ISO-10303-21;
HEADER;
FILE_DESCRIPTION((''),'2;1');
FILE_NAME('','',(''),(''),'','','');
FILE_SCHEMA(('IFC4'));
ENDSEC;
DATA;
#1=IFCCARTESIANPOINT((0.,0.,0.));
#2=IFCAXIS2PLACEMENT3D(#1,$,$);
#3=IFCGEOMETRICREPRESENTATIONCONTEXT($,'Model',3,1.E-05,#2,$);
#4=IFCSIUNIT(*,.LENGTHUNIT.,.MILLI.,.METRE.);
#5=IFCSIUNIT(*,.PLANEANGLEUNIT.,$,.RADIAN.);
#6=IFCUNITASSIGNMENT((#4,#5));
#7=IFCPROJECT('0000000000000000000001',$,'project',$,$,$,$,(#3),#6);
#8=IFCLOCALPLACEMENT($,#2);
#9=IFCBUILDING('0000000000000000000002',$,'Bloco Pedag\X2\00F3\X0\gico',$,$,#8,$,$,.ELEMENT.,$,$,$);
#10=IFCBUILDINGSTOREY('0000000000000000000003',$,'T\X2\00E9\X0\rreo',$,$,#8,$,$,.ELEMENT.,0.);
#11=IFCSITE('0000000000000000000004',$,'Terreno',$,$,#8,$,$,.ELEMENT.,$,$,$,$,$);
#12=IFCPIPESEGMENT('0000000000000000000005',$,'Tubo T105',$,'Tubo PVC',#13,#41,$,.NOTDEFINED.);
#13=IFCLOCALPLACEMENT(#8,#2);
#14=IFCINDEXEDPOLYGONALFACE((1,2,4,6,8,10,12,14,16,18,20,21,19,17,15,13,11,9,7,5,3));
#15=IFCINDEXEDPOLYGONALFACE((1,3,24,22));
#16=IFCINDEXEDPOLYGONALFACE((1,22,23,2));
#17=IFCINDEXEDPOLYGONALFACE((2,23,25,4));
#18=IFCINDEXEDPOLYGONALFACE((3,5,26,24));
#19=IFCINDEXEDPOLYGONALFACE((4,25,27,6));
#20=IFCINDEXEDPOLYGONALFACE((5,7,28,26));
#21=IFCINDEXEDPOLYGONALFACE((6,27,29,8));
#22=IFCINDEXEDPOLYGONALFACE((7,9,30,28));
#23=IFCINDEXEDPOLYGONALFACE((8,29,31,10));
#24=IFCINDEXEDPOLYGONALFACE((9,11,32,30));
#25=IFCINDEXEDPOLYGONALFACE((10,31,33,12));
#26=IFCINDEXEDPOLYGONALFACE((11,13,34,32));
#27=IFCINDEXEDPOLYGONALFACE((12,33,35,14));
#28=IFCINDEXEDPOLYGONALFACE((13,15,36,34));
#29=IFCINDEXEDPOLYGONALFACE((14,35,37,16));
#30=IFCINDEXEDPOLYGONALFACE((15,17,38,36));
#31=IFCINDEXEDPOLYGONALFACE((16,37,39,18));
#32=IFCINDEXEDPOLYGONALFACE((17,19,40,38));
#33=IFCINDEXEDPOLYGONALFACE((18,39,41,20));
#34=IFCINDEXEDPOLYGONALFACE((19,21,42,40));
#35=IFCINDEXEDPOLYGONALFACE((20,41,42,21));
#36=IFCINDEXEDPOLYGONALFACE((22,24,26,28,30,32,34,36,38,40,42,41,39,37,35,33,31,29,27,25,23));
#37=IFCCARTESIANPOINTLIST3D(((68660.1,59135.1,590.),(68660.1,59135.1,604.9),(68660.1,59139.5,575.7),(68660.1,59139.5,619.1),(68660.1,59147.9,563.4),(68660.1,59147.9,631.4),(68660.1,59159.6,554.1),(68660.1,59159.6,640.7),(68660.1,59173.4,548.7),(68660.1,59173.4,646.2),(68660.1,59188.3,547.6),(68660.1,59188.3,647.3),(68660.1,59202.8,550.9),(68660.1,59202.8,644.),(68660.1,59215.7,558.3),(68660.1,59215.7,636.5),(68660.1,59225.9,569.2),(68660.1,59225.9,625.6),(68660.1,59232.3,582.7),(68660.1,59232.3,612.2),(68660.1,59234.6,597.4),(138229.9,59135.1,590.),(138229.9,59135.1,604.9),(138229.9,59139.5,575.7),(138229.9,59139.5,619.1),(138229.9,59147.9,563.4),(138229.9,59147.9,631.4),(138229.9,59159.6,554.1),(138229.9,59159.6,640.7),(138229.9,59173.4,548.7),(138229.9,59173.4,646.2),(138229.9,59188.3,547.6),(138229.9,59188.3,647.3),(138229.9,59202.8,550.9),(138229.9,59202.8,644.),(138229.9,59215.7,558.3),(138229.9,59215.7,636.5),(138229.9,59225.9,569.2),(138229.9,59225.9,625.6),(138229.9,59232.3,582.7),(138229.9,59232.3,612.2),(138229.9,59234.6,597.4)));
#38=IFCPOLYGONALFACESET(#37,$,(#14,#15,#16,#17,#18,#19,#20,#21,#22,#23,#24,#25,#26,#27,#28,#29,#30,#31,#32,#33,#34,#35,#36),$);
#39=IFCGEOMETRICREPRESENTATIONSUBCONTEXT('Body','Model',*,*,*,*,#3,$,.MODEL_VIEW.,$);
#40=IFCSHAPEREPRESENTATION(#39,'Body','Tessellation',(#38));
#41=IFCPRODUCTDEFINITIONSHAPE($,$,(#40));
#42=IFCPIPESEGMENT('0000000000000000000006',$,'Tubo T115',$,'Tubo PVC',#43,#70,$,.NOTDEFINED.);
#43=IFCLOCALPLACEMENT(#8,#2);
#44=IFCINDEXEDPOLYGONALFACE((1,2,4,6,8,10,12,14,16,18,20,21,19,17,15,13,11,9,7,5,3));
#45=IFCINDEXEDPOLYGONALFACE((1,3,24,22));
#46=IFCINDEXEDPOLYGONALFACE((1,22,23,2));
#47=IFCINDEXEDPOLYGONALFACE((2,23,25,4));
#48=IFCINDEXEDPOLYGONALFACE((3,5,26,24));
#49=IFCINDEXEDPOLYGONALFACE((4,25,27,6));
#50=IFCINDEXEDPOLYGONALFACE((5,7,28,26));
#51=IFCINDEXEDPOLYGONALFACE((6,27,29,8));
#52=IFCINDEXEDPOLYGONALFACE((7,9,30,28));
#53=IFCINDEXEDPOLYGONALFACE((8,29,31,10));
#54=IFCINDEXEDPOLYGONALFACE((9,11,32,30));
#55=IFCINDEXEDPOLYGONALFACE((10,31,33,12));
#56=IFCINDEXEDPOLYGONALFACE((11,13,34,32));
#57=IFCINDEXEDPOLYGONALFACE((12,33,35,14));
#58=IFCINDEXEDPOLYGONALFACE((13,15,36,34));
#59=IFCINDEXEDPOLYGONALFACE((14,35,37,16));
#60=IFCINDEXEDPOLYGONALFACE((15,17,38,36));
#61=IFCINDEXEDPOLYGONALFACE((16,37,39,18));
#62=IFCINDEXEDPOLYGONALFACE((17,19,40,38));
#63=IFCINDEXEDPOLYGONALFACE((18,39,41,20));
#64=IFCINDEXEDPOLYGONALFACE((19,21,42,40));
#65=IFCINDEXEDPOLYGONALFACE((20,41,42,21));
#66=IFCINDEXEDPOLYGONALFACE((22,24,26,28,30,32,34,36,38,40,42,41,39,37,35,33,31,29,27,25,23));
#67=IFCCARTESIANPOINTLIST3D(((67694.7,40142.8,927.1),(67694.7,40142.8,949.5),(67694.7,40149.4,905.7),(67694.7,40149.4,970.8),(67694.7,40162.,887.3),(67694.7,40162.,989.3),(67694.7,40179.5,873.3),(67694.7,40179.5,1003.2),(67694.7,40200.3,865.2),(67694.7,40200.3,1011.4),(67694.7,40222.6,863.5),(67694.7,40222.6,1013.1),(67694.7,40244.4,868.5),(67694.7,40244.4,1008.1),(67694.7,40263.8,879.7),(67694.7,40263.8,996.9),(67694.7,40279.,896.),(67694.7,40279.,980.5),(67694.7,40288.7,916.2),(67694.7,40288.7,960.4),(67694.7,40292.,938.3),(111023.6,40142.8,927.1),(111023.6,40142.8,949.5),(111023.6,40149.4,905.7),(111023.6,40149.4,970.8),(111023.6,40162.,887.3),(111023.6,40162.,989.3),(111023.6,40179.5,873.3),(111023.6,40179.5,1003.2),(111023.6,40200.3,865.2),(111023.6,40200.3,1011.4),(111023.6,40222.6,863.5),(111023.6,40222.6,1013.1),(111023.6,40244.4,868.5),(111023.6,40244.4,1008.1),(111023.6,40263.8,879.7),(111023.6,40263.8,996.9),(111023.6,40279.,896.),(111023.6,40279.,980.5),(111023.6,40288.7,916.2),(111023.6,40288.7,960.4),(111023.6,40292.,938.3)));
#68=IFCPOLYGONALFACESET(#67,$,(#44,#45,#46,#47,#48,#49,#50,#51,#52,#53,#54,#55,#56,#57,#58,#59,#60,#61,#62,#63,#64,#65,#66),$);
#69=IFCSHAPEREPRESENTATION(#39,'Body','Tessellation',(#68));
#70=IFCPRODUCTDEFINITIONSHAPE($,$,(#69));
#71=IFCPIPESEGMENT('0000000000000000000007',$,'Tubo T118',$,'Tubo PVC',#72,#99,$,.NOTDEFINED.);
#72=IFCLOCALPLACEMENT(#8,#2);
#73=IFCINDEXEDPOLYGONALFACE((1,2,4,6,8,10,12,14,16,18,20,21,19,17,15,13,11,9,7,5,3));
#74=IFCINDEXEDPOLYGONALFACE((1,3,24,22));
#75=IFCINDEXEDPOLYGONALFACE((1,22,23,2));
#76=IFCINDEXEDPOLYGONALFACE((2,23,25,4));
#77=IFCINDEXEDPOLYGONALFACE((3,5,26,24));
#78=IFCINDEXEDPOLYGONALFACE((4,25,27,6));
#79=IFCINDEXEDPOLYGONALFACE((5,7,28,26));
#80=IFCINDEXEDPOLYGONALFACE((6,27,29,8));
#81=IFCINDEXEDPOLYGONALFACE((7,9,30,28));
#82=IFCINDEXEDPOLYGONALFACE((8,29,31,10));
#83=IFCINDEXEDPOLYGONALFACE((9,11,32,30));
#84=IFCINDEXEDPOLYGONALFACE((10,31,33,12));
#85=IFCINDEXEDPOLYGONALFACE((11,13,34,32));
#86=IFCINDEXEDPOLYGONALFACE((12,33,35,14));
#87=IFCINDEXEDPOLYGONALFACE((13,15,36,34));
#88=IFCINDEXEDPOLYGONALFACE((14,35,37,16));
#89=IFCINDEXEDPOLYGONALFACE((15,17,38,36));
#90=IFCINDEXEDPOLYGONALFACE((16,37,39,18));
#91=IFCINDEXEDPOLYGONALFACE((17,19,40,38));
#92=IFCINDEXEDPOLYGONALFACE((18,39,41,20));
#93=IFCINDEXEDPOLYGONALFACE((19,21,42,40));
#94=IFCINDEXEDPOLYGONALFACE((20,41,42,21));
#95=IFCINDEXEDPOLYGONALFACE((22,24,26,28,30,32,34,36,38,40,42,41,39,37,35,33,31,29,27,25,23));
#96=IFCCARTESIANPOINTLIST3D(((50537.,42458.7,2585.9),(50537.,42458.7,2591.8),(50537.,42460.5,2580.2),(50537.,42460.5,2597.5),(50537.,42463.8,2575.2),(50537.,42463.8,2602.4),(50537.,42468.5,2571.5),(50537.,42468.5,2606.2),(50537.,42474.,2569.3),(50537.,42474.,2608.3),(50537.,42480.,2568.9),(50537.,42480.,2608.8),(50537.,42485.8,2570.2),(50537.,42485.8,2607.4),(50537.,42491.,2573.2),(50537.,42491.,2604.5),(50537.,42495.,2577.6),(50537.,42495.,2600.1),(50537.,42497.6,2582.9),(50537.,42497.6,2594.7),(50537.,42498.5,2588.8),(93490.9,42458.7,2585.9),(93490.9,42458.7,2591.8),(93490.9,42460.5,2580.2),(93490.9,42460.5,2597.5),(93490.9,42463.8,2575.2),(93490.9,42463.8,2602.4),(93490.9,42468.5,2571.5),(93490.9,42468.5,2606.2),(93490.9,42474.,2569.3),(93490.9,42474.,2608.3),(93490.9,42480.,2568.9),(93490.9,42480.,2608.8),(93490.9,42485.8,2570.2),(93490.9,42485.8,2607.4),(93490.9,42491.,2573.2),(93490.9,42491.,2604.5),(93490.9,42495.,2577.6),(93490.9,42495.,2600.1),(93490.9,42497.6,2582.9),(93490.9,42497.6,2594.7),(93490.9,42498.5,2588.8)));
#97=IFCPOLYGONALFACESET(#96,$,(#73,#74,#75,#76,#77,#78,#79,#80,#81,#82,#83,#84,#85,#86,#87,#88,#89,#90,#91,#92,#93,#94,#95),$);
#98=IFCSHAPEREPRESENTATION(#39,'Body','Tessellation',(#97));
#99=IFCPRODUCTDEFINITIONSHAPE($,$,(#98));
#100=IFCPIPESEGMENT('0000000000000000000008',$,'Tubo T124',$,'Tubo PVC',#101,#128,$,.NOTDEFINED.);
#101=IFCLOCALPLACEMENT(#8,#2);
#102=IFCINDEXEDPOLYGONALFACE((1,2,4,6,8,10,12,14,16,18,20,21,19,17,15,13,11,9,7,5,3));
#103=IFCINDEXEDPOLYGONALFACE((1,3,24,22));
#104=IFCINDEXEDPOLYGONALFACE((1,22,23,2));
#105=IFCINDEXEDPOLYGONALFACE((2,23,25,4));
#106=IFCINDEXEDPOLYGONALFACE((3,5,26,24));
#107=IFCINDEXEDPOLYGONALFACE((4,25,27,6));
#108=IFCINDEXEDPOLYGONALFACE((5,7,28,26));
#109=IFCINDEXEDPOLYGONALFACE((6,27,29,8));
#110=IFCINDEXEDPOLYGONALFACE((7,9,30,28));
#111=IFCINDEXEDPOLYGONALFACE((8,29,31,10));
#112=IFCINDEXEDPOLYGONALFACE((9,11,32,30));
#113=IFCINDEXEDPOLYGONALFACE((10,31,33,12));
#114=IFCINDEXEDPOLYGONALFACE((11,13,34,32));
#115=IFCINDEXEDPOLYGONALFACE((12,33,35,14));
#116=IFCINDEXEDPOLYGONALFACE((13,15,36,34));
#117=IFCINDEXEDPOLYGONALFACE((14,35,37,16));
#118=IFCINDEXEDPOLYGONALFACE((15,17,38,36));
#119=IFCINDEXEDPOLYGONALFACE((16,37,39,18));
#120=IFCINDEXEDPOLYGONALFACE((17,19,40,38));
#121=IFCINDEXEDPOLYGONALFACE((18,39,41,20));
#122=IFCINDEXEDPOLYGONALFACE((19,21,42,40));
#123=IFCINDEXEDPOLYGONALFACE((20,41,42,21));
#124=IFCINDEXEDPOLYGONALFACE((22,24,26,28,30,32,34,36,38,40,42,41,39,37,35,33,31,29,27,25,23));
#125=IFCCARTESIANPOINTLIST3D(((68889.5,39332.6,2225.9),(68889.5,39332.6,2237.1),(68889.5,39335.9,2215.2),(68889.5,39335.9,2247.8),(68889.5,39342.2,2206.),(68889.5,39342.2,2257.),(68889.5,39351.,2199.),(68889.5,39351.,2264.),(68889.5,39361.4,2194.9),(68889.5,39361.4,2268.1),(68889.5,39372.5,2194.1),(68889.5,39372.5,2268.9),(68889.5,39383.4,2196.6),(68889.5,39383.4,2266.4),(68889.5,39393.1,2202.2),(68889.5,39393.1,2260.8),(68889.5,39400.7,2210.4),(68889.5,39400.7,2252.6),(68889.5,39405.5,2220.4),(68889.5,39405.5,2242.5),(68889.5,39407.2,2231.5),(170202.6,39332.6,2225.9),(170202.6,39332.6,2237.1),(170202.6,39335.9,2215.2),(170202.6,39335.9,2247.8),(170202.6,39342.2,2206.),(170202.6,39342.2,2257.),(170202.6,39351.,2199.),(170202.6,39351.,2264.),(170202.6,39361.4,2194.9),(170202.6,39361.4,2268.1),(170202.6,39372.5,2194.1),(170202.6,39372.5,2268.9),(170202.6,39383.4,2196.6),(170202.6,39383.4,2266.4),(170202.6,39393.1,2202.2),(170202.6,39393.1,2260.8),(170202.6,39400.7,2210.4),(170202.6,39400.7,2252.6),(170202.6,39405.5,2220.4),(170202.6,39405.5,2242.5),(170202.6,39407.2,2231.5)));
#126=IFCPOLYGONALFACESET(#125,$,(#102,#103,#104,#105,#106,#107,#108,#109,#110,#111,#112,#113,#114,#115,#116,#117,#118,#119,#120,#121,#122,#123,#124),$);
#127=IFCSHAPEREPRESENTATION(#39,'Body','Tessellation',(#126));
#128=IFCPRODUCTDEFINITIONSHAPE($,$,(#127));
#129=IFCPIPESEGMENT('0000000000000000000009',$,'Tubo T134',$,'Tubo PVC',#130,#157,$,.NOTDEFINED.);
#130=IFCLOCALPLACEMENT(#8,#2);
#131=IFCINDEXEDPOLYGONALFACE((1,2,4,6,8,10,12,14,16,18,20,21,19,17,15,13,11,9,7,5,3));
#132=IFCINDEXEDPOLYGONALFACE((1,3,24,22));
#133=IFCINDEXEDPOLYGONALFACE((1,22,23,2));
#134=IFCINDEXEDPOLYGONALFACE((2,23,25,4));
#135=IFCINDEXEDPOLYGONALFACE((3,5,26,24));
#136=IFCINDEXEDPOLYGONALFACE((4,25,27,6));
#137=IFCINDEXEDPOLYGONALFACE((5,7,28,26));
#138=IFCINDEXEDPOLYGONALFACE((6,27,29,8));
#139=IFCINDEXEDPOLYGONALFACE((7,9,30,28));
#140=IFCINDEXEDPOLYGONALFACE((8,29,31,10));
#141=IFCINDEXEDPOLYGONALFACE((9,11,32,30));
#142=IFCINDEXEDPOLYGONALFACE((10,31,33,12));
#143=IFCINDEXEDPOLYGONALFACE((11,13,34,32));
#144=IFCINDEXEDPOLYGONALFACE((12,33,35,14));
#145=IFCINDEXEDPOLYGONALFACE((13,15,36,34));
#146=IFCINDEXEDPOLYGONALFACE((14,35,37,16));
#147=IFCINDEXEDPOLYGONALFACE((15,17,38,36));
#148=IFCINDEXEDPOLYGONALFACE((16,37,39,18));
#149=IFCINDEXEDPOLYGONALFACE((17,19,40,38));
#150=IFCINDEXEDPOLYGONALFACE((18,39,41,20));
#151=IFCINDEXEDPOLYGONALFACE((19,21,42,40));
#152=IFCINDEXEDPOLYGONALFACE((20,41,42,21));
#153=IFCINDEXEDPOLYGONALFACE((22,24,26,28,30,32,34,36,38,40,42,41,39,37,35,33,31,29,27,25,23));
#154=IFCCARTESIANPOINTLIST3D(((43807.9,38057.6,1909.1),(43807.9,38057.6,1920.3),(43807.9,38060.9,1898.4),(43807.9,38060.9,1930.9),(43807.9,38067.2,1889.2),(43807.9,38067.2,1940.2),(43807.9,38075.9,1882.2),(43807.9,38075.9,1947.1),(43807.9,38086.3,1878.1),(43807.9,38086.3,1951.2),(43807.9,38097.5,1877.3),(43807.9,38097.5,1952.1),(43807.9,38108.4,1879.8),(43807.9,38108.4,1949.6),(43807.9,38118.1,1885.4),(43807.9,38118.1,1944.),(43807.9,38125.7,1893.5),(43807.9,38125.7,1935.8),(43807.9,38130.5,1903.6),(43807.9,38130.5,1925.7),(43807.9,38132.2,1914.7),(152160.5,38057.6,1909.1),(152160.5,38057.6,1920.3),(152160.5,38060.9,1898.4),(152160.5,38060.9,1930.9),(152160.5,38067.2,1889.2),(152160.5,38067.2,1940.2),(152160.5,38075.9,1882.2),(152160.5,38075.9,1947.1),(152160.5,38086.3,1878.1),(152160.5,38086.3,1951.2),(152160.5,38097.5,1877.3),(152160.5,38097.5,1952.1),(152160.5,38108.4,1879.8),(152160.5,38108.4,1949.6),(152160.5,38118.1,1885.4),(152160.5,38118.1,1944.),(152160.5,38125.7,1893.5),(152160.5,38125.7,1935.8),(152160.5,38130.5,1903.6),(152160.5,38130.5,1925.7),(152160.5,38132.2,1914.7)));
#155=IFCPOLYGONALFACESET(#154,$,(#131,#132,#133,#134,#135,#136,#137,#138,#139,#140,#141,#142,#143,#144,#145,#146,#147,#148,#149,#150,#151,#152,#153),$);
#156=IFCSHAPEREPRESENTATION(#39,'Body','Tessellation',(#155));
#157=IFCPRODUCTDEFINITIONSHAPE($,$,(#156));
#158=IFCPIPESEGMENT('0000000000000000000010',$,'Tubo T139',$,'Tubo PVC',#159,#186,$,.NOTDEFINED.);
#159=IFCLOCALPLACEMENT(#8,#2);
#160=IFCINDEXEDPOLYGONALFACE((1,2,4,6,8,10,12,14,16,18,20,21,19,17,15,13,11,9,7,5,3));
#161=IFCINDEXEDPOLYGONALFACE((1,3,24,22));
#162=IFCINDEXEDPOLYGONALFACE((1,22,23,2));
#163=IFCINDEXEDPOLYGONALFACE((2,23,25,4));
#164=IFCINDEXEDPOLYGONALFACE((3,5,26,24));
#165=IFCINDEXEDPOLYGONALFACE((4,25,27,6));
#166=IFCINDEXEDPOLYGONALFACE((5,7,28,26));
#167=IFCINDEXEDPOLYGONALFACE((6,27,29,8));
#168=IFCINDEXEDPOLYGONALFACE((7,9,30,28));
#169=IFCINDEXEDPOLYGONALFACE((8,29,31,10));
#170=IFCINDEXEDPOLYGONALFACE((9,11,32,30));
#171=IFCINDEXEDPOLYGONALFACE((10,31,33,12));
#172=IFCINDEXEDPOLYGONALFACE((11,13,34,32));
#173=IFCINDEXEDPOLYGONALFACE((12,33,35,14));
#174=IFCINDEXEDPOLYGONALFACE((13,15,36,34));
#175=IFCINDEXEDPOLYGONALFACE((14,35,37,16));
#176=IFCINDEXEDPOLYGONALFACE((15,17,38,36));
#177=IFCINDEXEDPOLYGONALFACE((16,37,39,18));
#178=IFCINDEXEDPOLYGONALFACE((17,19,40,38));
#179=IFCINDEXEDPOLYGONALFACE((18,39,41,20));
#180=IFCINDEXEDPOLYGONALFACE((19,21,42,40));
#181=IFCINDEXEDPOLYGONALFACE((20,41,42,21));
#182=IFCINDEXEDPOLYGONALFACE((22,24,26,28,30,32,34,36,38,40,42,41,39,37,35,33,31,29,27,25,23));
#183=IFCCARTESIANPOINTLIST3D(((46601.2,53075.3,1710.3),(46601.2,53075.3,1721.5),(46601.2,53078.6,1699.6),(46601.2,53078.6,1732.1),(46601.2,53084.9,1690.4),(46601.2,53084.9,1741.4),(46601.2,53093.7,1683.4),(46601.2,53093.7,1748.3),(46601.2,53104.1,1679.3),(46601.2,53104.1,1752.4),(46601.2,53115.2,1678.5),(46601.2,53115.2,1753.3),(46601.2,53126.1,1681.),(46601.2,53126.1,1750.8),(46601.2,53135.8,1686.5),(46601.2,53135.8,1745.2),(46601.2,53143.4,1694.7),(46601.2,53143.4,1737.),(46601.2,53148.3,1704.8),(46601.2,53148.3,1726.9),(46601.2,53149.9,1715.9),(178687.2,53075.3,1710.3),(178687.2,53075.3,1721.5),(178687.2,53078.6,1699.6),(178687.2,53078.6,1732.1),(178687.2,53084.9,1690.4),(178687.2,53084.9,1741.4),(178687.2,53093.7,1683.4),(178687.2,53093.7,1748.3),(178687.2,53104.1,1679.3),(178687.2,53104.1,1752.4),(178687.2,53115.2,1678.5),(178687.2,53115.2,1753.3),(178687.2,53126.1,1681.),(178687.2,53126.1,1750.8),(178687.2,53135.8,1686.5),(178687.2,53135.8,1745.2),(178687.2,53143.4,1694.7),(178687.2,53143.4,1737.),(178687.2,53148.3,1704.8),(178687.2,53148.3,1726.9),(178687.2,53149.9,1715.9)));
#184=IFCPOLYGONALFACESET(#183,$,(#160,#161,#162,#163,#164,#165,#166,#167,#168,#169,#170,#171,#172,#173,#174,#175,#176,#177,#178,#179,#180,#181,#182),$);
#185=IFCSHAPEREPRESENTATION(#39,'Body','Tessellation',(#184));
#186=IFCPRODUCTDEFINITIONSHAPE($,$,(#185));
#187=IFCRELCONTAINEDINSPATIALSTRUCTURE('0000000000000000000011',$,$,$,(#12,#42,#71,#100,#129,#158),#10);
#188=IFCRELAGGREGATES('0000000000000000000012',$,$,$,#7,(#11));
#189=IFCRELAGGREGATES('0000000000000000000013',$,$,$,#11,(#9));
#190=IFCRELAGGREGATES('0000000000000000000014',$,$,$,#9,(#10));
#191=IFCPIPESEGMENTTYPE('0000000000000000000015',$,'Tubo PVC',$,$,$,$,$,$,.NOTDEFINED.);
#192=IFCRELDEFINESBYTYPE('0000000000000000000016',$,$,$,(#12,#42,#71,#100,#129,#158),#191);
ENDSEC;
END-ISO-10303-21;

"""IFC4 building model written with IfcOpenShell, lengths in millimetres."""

from ifc_helpers import new_model, si_unit, frame, origin, origin_2d, place, context, subcontext, project, spatial, circle, extrude, type_object, element, save


model = new_model("IFC4")

# Units and contexts
model_context = context("Model", 3, precision=1e-05, world=origin())
body_context = subcontext(model_context, "Body", "Model", "MODEL_VIEW")
ifc_project = project(units=[si_unit("LENGTHUNIT", "METRE", prefix="MILLI"), si_unit("PLANEANGLEUNIT", "RADIAN")], contexts=[model_context])

# Site, building, storey
placement = place(None, origin())
site = spatial("IfcSite", under=ifc_project, at=placement, Name="Terreno", CompositionType="ELEMENT")
building = spatial("IfcBuilding", under=site, at=placement, Name="Bloco Pedagógico", CompositionType="ELEMENT")
storey = spatial("IfcBuildingStorey", under=building, at=placement, Name="Térreo", CompositionType="ELEMENT", Elevation=0.0)

# Pipe segments
pipe_segment_type = type_object("IfcPipeSegmentType", Name="Tubo PVC", PredefinedType="NOTDEFINED")
pipe_segment_1_placement = place(None, frame((68660.1, 59184.6, 597.4), z_axis=(1.0, 0.0, 0.0), x_axis=(0.0, 1.0, 0.0)))
element("IfcPipeSegment", 1, at=pipe_segment_1_placement, inside=storey, type_object=pipe_segment_type, Name="Tubo T105", ObjectType="Tubo PVC", PredefinedType="NOTDEFINED", context=body_context, shape_type="SweptSolid", body=[
    extrude(circle(Radius=50.0, at=origin_2d()), None, (0.0, 0.0, 1.0), 69569.8),
])
pipe_segment_2_placement = place(None, frame((67694.7, 40217.0, 938.3), z_axis=(1.0, 0.0, 0.0), x_axis=(0.0, 1.0, 0.0)))
element("IfcPipeSegment", 2, at=pipe_segment_2_placement, inside=storey, type_object=pipe_segment_type, Name="Tubo T115", ObjectType="Tubo PVC", PredefinedType="NOTDEFINED", context=body_context, shape_type="SweptSolid", body=[
    extrude(circle(Radius=75.0, at=origin_2d()), None, (0.0, 0.0, 1.0), 43328.9),
])
pipe_segment_3_placement = place(None, frame((50537.0, 42478.5, 2588.8), z_axis=(1.0, 0.0, 0.0), x_axis=(0.0, 1.0, 0.0)))
element("IfcPipeSegment", 3, at=pipe_segment_3_placement, inside=storey, type_object=pipe_segment_type, Name="Tubo T118", ObjectType="Tubo PVC", PredefinedType="NOTDEFINED", context=body_context, shape_type="SweptSolid", body=[
    extrude(circle(Radius=20.0, at=origin_2d()), None, (0.0, 0.0, 1.0), 42953.9),
])
pipe_segment_4_placement = place(None, frame((68889.5, 39369.7, 2231.5), z_axis=(1.0, 0.0, 0.0), x_axis=(0.0, 1.0, 0.0)))
element("IfcPipeSegment", 4, at=pipe_segment_4_placement, inside=storey, type_object=pipe_segment_type, Name="Tubo T124", ObjectType="Tubo PVC", PredefinedType="NOTDEFINED", context=body_context, shape_type="SweptSolid", body=[
    extrude(circle(Radius=37.5, at=origin_2d()), None, (0.0, 0.0, 1.0), 101313.1),
])
pipe_segment_5_placement = place(None, frame((43807.9, 38094.7, 1914.7), z_axis=(1.0, 0.0, 0.0), x_axis=(0.0, 1.0, 0.0)))
element("IfcPipeSegment", 5, at=pipe_segment_5_placement, inside=storey, type_object=pipe_segment_type, Name="Tubo T134", ObjectType="Tubo PVC", PredefinedType="NOTDEFINED", context=body_context, shape_type="SweptSolid", body=[
    extrude(circle(Radius=37.5, at=origin_2d()), None, (0.0, 0.0, 1.0), 108352.6),
])
pipe_segment_6_placement = place(None, frame((46601.2, 53112.4, 1715.9), z_axis=(1.0, 0.0, 0.0), x_axis=(0.0, 1.0, 0.0)))
element("IfcPipeSegment", 6, at=pipe_segment_6_placement, inside=storey, type_object=pipe_segment_type, Name="Tubo T139", ObjectType="Tubo PVC", PredefinedType="NOTDEFINED", context=body_context, shape_type="SweptSolid", body=[
    extrude(circle(Radius=37.5, at=origin_2d()), None, (0.0, 0.0, 1.0), 132086.0),
])

save(model, "model.ifc")
